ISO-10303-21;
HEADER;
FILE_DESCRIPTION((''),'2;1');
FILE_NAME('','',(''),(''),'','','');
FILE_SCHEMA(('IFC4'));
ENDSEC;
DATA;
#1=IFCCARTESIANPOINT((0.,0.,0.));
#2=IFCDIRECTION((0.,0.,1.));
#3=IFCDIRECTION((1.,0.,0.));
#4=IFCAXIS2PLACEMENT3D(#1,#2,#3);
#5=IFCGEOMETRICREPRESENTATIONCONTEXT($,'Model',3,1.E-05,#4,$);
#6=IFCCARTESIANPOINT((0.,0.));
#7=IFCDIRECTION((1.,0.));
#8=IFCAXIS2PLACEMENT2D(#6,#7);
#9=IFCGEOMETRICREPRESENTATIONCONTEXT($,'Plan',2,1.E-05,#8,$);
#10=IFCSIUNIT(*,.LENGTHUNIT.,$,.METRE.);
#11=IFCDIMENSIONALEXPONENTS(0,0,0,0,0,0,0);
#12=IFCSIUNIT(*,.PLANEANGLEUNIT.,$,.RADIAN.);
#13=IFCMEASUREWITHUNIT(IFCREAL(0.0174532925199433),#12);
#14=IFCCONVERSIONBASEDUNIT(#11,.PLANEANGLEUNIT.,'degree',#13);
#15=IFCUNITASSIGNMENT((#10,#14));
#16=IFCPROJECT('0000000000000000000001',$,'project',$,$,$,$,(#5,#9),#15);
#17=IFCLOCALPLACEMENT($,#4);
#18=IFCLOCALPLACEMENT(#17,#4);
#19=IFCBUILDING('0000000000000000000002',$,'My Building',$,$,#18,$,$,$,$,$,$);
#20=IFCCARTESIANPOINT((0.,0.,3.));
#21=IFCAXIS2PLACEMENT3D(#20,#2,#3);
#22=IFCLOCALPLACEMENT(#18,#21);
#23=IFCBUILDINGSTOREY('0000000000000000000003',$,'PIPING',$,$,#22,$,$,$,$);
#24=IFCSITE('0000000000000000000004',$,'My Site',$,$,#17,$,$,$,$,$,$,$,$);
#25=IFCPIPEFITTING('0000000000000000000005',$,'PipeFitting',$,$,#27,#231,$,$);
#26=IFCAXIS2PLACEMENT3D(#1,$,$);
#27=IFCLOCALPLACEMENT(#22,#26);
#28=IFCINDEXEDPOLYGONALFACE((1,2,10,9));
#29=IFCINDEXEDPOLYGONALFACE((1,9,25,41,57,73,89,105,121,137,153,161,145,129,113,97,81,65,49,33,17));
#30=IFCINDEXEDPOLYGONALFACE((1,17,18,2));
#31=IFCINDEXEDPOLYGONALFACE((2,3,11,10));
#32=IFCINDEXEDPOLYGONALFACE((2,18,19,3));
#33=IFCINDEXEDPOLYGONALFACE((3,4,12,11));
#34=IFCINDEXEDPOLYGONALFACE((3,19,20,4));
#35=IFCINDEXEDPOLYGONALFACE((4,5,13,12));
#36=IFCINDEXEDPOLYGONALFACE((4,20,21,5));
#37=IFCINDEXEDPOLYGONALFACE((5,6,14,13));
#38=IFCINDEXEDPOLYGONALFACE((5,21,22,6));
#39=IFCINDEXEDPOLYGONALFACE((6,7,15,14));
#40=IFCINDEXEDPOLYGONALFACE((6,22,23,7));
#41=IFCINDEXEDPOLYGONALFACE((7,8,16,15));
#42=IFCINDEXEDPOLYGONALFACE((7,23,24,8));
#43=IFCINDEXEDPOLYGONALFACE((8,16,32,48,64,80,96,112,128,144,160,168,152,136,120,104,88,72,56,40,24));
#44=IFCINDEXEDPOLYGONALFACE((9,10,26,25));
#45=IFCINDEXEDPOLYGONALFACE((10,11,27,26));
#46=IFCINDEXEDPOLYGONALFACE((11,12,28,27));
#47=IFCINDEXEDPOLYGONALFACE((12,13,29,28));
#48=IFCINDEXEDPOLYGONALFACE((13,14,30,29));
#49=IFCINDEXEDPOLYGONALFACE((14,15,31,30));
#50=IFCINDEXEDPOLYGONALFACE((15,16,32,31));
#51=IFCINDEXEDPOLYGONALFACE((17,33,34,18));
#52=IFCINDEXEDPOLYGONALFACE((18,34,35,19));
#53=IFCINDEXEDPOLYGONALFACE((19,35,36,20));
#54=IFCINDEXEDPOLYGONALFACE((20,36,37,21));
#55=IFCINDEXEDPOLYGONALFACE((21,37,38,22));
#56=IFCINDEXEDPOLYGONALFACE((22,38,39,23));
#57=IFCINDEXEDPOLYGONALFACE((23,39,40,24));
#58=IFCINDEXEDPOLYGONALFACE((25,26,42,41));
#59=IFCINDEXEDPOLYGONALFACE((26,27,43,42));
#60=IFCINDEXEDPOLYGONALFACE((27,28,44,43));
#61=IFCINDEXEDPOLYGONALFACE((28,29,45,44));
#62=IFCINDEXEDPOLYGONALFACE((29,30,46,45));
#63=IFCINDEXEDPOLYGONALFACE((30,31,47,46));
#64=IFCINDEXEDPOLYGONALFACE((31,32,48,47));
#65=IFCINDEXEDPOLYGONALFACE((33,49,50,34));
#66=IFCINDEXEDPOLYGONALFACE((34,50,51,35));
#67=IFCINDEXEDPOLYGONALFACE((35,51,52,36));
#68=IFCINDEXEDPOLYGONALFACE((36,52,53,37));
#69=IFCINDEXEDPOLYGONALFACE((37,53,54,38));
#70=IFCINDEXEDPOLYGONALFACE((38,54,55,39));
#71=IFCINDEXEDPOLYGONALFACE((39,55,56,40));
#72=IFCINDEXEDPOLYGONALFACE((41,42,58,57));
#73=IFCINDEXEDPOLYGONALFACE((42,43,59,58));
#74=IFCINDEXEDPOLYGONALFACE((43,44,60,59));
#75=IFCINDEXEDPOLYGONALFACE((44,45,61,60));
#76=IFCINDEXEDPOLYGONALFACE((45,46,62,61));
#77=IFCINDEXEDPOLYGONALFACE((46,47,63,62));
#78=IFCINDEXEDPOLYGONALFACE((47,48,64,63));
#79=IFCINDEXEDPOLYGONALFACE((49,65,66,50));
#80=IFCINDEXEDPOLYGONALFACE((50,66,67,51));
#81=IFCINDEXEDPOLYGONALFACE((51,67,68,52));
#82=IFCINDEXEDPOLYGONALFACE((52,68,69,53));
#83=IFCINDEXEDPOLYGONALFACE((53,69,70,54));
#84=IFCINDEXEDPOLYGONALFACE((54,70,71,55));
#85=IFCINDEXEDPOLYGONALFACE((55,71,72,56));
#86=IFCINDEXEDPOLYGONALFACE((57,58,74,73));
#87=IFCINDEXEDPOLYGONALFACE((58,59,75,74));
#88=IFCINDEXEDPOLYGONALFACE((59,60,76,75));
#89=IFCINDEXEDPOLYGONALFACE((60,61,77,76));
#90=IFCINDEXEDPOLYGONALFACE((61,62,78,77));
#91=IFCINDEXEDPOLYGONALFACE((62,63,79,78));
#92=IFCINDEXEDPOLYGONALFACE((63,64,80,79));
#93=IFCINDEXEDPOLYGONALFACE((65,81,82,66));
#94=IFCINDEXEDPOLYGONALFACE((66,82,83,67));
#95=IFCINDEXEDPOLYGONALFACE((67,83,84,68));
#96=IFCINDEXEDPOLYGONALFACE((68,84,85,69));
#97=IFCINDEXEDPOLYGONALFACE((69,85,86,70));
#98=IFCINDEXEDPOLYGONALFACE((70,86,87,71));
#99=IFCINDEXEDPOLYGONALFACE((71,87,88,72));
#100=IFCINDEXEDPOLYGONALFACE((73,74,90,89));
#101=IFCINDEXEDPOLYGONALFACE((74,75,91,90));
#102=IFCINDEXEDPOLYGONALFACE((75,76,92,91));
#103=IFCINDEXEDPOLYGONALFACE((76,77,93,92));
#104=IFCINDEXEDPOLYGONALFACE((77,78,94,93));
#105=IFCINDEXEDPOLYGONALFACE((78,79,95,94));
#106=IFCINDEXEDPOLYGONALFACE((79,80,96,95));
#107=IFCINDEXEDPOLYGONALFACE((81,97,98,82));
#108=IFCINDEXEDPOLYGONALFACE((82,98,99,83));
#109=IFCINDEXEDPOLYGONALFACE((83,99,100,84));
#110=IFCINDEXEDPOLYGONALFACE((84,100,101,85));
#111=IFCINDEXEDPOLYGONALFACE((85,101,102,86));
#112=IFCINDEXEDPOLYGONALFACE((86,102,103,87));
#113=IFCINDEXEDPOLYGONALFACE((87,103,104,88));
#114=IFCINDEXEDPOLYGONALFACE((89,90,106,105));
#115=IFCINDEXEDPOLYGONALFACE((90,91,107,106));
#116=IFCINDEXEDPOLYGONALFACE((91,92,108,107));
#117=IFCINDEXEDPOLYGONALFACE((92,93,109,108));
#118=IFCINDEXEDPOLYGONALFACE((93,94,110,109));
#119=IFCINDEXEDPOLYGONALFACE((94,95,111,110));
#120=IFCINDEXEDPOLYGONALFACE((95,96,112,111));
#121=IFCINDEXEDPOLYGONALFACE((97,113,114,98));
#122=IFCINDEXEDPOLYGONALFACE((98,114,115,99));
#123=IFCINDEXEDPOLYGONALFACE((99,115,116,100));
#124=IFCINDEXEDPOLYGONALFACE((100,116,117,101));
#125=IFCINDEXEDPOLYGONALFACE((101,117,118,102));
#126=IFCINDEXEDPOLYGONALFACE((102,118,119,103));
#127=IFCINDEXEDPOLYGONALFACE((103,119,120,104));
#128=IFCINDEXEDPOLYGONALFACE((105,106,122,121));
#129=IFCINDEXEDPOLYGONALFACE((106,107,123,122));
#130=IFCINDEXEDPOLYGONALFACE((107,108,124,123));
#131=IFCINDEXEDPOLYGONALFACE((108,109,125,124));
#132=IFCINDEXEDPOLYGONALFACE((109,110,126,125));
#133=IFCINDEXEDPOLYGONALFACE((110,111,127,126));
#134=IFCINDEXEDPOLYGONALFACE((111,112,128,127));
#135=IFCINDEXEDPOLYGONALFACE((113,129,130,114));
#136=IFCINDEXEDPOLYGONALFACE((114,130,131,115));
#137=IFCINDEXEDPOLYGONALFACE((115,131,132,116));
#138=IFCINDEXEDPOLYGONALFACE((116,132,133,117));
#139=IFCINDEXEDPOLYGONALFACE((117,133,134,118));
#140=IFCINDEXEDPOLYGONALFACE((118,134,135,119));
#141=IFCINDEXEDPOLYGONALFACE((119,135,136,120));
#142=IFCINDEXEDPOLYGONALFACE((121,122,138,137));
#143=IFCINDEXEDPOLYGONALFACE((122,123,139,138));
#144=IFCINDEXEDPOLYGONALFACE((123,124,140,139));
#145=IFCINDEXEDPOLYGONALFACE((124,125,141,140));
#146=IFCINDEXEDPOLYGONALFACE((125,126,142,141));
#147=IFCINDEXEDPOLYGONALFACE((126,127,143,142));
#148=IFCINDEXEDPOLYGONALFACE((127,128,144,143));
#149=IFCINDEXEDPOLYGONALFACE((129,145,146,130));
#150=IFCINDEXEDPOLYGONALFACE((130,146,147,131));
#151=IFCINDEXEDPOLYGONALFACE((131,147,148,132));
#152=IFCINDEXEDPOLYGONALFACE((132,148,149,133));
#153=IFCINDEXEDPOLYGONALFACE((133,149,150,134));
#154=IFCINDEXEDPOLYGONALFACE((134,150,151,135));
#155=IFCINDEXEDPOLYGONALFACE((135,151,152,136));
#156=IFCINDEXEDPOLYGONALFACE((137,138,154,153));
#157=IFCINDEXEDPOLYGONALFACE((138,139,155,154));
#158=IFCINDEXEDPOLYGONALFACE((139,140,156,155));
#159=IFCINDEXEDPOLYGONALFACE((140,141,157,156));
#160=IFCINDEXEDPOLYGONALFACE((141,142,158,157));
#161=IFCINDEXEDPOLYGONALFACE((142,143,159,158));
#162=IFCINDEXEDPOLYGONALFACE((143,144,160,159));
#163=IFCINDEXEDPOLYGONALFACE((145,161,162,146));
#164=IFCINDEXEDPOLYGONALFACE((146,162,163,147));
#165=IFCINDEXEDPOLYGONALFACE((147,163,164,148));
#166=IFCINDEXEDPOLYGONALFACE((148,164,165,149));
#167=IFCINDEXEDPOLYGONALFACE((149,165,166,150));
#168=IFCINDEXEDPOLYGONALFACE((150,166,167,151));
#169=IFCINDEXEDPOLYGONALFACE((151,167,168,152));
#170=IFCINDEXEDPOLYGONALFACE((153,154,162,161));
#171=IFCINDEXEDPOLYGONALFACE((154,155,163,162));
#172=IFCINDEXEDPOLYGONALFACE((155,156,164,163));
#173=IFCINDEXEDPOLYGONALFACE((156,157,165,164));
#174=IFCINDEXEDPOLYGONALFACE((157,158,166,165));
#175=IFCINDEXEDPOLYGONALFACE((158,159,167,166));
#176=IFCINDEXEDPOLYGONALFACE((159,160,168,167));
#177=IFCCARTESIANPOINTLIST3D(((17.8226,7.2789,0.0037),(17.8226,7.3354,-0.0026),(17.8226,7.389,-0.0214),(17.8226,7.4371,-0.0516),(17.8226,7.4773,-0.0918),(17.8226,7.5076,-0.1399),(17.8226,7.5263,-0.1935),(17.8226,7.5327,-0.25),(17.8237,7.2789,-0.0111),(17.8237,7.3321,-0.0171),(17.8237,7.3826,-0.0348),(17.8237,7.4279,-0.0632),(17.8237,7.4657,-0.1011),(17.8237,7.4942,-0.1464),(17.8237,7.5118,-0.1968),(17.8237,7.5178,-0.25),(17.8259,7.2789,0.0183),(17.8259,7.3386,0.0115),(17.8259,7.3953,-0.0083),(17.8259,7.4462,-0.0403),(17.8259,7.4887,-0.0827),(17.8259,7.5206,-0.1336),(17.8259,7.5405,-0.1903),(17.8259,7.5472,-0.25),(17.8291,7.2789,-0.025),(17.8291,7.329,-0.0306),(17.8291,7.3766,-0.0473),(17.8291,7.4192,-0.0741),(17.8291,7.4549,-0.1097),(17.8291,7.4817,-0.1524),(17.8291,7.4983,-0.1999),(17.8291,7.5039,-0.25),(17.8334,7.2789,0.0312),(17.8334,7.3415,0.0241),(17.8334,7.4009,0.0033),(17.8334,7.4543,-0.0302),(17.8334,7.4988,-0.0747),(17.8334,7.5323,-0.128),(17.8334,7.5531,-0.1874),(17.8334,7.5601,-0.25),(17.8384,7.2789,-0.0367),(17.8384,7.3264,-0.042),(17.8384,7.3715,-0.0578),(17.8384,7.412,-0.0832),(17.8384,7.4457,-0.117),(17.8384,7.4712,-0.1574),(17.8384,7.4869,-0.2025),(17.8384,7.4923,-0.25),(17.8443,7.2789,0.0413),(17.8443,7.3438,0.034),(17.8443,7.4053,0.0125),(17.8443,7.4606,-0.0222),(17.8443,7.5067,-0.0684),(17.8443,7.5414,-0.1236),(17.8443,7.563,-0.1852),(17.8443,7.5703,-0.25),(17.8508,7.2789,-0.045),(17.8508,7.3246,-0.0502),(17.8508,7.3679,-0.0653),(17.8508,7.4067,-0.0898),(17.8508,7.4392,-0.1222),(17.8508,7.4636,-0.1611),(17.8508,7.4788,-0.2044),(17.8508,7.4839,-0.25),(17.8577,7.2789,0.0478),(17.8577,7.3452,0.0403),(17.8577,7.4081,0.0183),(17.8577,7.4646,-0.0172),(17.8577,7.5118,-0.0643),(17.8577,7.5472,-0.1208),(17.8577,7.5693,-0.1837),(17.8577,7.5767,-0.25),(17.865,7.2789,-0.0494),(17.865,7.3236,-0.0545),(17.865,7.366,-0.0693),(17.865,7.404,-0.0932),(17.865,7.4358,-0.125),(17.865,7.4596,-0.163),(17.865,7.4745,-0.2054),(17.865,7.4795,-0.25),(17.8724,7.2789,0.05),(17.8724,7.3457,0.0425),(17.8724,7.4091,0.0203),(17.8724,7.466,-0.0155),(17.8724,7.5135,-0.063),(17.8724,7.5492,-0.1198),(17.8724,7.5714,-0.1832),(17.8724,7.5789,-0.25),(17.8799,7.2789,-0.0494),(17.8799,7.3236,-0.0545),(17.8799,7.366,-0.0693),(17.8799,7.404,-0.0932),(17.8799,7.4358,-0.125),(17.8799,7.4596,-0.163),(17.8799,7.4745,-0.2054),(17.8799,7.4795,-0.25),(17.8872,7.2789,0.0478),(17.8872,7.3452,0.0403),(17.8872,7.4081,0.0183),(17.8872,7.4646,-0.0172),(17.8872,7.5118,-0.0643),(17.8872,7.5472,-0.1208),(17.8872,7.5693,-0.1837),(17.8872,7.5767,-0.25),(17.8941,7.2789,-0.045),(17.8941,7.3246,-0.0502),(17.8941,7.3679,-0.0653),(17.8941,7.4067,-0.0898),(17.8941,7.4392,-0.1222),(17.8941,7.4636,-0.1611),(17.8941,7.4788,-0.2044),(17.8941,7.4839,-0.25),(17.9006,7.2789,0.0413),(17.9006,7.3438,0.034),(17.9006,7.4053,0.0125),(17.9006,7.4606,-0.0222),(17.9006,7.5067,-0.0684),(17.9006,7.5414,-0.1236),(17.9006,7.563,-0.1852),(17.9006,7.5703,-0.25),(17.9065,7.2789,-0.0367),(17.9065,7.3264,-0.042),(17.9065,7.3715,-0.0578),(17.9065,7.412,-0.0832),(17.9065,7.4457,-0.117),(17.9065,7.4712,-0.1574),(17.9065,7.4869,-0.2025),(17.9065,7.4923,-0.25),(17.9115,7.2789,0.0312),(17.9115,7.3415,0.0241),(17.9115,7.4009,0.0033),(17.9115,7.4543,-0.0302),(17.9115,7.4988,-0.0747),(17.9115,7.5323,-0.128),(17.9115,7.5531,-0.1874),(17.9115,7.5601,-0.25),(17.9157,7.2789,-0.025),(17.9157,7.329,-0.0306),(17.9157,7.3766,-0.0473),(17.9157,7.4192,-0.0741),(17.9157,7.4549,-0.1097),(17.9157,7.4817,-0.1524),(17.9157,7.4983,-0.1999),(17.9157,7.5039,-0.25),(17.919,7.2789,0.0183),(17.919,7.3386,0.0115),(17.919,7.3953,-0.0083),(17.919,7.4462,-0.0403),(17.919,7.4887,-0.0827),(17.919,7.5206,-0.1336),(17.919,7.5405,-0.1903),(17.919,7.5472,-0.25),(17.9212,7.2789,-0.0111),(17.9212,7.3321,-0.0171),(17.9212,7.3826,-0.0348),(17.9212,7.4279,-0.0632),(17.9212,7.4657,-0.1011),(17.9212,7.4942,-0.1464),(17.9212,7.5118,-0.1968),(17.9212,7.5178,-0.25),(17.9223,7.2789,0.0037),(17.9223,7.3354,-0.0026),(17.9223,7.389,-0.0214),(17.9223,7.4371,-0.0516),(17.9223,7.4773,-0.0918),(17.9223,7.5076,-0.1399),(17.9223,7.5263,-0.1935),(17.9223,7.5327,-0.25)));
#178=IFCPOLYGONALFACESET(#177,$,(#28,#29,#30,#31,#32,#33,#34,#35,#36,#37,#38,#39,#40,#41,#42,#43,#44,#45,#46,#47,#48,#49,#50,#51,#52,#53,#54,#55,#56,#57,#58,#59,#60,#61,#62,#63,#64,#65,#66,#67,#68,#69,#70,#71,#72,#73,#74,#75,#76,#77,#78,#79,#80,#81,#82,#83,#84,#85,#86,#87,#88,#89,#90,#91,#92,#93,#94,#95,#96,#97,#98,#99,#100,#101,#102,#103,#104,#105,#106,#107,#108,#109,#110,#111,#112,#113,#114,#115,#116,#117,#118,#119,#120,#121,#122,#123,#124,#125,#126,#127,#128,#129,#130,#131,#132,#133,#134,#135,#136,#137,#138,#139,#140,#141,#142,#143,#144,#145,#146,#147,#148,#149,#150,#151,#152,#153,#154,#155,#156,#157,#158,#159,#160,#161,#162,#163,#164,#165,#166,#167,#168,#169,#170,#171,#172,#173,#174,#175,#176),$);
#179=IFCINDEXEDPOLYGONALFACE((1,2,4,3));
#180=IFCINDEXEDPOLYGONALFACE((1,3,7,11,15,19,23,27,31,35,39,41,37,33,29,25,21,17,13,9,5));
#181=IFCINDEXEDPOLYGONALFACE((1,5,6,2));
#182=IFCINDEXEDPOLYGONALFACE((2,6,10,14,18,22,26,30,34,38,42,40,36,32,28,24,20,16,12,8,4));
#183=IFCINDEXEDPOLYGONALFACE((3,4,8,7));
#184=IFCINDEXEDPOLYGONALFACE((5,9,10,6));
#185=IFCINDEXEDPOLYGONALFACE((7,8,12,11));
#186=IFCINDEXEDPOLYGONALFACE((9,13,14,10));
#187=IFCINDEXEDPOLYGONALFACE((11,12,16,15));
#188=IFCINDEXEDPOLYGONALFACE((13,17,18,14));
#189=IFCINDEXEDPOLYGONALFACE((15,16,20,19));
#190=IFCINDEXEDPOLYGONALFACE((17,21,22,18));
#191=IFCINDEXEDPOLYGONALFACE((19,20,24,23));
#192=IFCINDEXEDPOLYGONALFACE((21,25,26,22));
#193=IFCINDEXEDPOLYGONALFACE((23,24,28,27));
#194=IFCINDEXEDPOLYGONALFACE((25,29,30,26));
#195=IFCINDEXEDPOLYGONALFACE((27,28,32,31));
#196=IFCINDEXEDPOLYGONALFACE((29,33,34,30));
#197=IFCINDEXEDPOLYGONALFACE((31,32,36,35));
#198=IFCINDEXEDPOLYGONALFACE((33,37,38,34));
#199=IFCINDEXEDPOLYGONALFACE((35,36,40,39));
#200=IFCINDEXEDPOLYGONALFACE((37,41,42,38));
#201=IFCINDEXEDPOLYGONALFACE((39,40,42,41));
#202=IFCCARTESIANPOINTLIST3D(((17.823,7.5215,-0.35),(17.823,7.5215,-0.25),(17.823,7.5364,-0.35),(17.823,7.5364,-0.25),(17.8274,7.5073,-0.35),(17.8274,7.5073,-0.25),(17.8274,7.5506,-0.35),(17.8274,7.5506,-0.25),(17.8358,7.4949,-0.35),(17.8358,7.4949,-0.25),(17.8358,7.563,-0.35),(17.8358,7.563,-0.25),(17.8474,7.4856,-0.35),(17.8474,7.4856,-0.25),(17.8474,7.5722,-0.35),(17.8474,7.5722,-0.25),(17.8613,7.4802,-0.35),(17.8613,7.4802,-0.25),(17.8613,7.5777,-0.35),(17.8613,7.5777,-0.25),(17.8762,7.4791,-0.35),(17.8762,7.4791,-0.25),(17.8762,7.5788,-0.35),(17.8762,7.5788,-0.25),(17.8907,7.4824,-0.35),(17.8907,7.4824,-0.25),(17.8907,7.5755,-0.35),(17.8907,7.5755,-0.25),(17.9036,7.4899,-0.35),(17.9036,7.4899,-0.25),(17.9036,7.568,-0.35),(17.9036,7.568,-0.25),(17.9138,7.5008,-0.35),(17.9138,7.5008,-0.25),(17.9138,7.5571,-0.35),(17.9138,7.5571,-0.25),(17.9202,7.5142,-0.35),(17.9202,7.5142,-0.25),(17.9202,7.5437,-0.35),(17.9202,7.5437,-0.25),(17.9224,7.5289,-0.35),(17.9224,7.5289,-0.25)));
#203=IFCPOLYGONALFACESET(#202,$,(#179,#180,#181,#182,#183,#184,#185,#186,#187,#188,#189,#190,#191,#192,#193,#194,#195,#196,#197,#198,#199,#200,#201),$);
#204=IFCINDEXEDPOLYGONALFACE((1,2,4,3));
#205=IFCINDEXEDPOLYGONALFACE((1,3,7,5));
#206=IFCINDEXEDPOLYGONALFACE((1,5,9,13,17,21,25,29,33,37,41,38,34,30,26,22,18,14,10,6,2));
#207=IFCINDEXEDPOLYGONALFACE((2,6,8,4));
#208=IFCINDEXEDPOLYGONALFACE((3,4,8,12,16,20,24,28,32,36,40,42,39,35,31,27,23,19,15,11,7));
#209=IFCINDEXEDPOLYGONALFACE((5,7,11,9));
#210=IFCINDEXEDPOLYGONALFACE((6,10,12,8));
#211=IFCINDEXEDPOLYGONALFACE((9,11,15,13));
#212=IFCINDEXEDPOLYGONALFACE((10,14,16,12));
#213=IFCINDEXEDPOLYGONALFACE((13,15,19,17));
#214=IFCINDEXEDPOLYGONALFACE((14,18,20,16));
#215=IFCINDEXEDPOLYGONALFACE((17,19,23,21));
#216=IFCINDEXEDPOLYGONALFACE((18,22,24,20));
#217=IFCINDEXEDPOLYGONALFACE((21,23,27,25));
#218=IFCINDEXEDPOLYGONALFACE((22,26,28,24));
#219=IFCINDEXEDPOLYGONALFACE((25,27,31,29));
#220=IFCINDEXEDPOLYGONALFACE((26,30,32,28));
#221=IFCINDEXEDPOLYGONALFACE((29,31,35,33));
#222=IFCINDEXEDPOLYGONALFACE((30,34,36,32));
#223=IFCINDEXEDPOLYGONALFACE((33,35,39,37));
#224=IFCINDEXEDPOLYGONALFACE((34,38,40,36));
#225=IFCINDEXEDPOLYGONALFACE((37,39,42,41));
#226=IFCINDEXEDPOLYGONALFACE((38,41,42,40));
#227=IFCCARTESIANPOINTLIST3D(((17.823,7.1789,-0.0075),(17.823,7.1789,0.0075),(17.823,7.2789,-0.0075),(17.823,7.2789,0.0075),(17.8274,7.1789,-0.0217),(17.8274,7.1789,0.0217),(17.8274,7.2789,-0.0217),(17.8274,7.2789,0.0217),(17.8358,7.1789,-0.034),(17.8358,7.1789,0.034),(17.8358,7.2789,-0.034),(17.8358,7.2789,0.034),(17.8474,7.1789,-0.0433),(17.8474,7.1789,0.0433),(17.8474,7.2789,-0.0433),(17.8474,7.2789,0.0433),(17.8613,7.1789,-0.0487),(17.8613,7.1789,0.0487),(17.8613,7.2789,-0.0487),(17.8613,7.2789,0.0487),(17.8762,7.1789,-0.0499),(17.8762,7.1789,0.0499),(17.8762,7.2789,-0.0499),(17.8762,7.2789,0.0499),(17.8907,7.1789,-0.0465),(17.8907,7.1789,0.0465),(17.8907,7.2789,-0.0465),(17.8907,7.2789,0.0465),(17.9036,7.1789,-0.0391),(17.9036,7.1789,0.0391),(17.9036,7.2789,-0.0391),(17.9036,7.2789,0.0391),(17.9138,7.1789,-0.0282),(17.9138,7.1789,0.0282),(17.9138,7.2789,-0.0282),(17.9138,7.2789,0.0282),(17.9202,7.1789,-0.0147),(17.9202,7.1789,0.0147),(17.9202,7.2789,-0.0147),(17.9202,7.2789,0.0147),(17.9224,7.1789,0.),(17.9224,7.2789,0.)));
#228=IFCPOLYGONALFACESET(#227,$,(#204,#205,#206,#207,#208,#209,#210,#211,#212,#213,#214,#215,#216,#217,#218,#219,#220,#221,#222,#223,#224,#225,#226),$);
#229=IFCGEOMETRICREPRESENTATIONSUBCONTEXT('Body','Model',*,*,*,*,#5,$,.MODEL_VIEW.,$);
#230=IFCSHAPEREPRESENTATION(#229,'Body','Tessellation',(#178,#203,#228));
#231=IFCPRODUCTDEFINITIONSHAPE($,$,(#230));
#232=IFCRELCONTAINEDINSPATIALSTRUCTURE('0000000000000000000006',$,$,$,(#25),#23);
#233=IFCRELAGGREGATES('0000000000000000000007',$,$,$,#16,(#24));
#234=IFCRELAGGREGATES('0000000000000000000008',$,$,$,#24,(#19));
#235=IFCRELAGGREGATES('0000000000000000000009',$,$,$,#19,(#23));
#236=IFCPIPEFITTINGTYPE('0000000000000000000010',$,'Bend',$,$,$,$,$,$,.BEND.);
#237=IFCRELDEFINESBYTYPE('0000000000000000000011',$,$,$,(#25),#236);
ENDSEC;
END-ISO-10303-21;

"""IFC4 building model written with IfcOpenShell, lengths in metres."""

from ifc_helpers import new_model, entity, si_unit, converted_unit, frame, origin_with_axes, origin_2d_with_axis, place, context, subcontext, project, spatial, circle, extrude, source, transform, mapped, type_object, type_shapes, element, save


model = new_model("IFC4")

# Units and contexts
model_context = context("Model", 3, precision=1e-05, world=origin_with_axes())
plan_context = context("Plan", 2, precision=1e-05, world=origin_2d_with_axis())
body_context = subcontext(model_context, "Body", "Model", "MODEL_VIEW")
ifc_project = project(units=[si_unit("LENGTHUNIT", "METRE"), converted_unit("PLANEANGLEUNIT", "degree", entity("IfcReal", 0.0174532925199433), si_unit("PLANEANGLEUNIT", "RADIAN"), dimensions=[0, 0, 0, 0, 0, 0, 0])], contexts=[model_context, plan_context])

# Site, building, storey
site_placement = place(None, origin_with_axes())
site = spatial("IfcSite", under=ifc_project, at=site_placement, Name="My Site")
building_placement = place(site_placement, origin_with_axes())
building = spatial("IfcBuilding", under=site, at=building_placement, Name="My Building")
storey_placement = place(building_placement, frame((0.0, 0.0, 3.0), z_axis=(0.0, 0.0, 1.0), x_axis=(1.0, 0.0, 0.0)))
storey = spatial("IfcBuildingStorey", under=building, at=storey_placement, Name="PIPING")

# Shared definitions
pipe_fitting_type_1 = type_object("IfcPipeFittingType", Name="Bend", PredefinedType="BEND")
shared_shape = source(origin_with_axes(), body_context, "Body", "SolidModel", [
    entity("IfcSweptDiskSolid", entity("IfcIndexedPolyCurve", entity("IfcCartesianPointList3D", [[0.0, 0.0, -0.1], [0.0, 0.0732, -0.2768], [0.0, 0.25, -0.35]]), [entity("IfcArcIndex", [1, 2, 3])]), 0.05),
    extrude(circle(Radius=0.05), origin_with_axes(), (0.0, 0.0, -1.0), 0.1),
    extrude(circle(Radius=0.05), frame((0.0, 0.25, -0.35), z_axis=(0.0, 1.0, 0.0), x_axis=(1.0, 0.0, 0.0)), (0.0, 0.0, 1.0), 0.1),
])
type_shapes(pipe_fitting_type_1, [shared_shape])

# Pipe fitting
pipe_fitting_1_placement = place(storey_placement, frame((17.8724, 7.5289, -0.35), z_axis=(0.0, 0.0, -1.0), x_axis=(1.0, 0.0, 0.0)))
element("IfcPipeFitting", 1, at=pipe_fitting_1_placement, inside=storey, type_object=pipe_fitting_type_1, Name="PipeFitting", context=body_context, shape_type="MappedRepresentation", body=[
    mapped(shared_shape, transform((0.0, 0.0, 0.0), x_axis=(1.0, 0.0, 0.0), y_axis=(0.0, 1.0, 0.0), z_axis=(0.0, 0.0, 1.0), scale=1.0)),
])

save(model, "model.ifc")
